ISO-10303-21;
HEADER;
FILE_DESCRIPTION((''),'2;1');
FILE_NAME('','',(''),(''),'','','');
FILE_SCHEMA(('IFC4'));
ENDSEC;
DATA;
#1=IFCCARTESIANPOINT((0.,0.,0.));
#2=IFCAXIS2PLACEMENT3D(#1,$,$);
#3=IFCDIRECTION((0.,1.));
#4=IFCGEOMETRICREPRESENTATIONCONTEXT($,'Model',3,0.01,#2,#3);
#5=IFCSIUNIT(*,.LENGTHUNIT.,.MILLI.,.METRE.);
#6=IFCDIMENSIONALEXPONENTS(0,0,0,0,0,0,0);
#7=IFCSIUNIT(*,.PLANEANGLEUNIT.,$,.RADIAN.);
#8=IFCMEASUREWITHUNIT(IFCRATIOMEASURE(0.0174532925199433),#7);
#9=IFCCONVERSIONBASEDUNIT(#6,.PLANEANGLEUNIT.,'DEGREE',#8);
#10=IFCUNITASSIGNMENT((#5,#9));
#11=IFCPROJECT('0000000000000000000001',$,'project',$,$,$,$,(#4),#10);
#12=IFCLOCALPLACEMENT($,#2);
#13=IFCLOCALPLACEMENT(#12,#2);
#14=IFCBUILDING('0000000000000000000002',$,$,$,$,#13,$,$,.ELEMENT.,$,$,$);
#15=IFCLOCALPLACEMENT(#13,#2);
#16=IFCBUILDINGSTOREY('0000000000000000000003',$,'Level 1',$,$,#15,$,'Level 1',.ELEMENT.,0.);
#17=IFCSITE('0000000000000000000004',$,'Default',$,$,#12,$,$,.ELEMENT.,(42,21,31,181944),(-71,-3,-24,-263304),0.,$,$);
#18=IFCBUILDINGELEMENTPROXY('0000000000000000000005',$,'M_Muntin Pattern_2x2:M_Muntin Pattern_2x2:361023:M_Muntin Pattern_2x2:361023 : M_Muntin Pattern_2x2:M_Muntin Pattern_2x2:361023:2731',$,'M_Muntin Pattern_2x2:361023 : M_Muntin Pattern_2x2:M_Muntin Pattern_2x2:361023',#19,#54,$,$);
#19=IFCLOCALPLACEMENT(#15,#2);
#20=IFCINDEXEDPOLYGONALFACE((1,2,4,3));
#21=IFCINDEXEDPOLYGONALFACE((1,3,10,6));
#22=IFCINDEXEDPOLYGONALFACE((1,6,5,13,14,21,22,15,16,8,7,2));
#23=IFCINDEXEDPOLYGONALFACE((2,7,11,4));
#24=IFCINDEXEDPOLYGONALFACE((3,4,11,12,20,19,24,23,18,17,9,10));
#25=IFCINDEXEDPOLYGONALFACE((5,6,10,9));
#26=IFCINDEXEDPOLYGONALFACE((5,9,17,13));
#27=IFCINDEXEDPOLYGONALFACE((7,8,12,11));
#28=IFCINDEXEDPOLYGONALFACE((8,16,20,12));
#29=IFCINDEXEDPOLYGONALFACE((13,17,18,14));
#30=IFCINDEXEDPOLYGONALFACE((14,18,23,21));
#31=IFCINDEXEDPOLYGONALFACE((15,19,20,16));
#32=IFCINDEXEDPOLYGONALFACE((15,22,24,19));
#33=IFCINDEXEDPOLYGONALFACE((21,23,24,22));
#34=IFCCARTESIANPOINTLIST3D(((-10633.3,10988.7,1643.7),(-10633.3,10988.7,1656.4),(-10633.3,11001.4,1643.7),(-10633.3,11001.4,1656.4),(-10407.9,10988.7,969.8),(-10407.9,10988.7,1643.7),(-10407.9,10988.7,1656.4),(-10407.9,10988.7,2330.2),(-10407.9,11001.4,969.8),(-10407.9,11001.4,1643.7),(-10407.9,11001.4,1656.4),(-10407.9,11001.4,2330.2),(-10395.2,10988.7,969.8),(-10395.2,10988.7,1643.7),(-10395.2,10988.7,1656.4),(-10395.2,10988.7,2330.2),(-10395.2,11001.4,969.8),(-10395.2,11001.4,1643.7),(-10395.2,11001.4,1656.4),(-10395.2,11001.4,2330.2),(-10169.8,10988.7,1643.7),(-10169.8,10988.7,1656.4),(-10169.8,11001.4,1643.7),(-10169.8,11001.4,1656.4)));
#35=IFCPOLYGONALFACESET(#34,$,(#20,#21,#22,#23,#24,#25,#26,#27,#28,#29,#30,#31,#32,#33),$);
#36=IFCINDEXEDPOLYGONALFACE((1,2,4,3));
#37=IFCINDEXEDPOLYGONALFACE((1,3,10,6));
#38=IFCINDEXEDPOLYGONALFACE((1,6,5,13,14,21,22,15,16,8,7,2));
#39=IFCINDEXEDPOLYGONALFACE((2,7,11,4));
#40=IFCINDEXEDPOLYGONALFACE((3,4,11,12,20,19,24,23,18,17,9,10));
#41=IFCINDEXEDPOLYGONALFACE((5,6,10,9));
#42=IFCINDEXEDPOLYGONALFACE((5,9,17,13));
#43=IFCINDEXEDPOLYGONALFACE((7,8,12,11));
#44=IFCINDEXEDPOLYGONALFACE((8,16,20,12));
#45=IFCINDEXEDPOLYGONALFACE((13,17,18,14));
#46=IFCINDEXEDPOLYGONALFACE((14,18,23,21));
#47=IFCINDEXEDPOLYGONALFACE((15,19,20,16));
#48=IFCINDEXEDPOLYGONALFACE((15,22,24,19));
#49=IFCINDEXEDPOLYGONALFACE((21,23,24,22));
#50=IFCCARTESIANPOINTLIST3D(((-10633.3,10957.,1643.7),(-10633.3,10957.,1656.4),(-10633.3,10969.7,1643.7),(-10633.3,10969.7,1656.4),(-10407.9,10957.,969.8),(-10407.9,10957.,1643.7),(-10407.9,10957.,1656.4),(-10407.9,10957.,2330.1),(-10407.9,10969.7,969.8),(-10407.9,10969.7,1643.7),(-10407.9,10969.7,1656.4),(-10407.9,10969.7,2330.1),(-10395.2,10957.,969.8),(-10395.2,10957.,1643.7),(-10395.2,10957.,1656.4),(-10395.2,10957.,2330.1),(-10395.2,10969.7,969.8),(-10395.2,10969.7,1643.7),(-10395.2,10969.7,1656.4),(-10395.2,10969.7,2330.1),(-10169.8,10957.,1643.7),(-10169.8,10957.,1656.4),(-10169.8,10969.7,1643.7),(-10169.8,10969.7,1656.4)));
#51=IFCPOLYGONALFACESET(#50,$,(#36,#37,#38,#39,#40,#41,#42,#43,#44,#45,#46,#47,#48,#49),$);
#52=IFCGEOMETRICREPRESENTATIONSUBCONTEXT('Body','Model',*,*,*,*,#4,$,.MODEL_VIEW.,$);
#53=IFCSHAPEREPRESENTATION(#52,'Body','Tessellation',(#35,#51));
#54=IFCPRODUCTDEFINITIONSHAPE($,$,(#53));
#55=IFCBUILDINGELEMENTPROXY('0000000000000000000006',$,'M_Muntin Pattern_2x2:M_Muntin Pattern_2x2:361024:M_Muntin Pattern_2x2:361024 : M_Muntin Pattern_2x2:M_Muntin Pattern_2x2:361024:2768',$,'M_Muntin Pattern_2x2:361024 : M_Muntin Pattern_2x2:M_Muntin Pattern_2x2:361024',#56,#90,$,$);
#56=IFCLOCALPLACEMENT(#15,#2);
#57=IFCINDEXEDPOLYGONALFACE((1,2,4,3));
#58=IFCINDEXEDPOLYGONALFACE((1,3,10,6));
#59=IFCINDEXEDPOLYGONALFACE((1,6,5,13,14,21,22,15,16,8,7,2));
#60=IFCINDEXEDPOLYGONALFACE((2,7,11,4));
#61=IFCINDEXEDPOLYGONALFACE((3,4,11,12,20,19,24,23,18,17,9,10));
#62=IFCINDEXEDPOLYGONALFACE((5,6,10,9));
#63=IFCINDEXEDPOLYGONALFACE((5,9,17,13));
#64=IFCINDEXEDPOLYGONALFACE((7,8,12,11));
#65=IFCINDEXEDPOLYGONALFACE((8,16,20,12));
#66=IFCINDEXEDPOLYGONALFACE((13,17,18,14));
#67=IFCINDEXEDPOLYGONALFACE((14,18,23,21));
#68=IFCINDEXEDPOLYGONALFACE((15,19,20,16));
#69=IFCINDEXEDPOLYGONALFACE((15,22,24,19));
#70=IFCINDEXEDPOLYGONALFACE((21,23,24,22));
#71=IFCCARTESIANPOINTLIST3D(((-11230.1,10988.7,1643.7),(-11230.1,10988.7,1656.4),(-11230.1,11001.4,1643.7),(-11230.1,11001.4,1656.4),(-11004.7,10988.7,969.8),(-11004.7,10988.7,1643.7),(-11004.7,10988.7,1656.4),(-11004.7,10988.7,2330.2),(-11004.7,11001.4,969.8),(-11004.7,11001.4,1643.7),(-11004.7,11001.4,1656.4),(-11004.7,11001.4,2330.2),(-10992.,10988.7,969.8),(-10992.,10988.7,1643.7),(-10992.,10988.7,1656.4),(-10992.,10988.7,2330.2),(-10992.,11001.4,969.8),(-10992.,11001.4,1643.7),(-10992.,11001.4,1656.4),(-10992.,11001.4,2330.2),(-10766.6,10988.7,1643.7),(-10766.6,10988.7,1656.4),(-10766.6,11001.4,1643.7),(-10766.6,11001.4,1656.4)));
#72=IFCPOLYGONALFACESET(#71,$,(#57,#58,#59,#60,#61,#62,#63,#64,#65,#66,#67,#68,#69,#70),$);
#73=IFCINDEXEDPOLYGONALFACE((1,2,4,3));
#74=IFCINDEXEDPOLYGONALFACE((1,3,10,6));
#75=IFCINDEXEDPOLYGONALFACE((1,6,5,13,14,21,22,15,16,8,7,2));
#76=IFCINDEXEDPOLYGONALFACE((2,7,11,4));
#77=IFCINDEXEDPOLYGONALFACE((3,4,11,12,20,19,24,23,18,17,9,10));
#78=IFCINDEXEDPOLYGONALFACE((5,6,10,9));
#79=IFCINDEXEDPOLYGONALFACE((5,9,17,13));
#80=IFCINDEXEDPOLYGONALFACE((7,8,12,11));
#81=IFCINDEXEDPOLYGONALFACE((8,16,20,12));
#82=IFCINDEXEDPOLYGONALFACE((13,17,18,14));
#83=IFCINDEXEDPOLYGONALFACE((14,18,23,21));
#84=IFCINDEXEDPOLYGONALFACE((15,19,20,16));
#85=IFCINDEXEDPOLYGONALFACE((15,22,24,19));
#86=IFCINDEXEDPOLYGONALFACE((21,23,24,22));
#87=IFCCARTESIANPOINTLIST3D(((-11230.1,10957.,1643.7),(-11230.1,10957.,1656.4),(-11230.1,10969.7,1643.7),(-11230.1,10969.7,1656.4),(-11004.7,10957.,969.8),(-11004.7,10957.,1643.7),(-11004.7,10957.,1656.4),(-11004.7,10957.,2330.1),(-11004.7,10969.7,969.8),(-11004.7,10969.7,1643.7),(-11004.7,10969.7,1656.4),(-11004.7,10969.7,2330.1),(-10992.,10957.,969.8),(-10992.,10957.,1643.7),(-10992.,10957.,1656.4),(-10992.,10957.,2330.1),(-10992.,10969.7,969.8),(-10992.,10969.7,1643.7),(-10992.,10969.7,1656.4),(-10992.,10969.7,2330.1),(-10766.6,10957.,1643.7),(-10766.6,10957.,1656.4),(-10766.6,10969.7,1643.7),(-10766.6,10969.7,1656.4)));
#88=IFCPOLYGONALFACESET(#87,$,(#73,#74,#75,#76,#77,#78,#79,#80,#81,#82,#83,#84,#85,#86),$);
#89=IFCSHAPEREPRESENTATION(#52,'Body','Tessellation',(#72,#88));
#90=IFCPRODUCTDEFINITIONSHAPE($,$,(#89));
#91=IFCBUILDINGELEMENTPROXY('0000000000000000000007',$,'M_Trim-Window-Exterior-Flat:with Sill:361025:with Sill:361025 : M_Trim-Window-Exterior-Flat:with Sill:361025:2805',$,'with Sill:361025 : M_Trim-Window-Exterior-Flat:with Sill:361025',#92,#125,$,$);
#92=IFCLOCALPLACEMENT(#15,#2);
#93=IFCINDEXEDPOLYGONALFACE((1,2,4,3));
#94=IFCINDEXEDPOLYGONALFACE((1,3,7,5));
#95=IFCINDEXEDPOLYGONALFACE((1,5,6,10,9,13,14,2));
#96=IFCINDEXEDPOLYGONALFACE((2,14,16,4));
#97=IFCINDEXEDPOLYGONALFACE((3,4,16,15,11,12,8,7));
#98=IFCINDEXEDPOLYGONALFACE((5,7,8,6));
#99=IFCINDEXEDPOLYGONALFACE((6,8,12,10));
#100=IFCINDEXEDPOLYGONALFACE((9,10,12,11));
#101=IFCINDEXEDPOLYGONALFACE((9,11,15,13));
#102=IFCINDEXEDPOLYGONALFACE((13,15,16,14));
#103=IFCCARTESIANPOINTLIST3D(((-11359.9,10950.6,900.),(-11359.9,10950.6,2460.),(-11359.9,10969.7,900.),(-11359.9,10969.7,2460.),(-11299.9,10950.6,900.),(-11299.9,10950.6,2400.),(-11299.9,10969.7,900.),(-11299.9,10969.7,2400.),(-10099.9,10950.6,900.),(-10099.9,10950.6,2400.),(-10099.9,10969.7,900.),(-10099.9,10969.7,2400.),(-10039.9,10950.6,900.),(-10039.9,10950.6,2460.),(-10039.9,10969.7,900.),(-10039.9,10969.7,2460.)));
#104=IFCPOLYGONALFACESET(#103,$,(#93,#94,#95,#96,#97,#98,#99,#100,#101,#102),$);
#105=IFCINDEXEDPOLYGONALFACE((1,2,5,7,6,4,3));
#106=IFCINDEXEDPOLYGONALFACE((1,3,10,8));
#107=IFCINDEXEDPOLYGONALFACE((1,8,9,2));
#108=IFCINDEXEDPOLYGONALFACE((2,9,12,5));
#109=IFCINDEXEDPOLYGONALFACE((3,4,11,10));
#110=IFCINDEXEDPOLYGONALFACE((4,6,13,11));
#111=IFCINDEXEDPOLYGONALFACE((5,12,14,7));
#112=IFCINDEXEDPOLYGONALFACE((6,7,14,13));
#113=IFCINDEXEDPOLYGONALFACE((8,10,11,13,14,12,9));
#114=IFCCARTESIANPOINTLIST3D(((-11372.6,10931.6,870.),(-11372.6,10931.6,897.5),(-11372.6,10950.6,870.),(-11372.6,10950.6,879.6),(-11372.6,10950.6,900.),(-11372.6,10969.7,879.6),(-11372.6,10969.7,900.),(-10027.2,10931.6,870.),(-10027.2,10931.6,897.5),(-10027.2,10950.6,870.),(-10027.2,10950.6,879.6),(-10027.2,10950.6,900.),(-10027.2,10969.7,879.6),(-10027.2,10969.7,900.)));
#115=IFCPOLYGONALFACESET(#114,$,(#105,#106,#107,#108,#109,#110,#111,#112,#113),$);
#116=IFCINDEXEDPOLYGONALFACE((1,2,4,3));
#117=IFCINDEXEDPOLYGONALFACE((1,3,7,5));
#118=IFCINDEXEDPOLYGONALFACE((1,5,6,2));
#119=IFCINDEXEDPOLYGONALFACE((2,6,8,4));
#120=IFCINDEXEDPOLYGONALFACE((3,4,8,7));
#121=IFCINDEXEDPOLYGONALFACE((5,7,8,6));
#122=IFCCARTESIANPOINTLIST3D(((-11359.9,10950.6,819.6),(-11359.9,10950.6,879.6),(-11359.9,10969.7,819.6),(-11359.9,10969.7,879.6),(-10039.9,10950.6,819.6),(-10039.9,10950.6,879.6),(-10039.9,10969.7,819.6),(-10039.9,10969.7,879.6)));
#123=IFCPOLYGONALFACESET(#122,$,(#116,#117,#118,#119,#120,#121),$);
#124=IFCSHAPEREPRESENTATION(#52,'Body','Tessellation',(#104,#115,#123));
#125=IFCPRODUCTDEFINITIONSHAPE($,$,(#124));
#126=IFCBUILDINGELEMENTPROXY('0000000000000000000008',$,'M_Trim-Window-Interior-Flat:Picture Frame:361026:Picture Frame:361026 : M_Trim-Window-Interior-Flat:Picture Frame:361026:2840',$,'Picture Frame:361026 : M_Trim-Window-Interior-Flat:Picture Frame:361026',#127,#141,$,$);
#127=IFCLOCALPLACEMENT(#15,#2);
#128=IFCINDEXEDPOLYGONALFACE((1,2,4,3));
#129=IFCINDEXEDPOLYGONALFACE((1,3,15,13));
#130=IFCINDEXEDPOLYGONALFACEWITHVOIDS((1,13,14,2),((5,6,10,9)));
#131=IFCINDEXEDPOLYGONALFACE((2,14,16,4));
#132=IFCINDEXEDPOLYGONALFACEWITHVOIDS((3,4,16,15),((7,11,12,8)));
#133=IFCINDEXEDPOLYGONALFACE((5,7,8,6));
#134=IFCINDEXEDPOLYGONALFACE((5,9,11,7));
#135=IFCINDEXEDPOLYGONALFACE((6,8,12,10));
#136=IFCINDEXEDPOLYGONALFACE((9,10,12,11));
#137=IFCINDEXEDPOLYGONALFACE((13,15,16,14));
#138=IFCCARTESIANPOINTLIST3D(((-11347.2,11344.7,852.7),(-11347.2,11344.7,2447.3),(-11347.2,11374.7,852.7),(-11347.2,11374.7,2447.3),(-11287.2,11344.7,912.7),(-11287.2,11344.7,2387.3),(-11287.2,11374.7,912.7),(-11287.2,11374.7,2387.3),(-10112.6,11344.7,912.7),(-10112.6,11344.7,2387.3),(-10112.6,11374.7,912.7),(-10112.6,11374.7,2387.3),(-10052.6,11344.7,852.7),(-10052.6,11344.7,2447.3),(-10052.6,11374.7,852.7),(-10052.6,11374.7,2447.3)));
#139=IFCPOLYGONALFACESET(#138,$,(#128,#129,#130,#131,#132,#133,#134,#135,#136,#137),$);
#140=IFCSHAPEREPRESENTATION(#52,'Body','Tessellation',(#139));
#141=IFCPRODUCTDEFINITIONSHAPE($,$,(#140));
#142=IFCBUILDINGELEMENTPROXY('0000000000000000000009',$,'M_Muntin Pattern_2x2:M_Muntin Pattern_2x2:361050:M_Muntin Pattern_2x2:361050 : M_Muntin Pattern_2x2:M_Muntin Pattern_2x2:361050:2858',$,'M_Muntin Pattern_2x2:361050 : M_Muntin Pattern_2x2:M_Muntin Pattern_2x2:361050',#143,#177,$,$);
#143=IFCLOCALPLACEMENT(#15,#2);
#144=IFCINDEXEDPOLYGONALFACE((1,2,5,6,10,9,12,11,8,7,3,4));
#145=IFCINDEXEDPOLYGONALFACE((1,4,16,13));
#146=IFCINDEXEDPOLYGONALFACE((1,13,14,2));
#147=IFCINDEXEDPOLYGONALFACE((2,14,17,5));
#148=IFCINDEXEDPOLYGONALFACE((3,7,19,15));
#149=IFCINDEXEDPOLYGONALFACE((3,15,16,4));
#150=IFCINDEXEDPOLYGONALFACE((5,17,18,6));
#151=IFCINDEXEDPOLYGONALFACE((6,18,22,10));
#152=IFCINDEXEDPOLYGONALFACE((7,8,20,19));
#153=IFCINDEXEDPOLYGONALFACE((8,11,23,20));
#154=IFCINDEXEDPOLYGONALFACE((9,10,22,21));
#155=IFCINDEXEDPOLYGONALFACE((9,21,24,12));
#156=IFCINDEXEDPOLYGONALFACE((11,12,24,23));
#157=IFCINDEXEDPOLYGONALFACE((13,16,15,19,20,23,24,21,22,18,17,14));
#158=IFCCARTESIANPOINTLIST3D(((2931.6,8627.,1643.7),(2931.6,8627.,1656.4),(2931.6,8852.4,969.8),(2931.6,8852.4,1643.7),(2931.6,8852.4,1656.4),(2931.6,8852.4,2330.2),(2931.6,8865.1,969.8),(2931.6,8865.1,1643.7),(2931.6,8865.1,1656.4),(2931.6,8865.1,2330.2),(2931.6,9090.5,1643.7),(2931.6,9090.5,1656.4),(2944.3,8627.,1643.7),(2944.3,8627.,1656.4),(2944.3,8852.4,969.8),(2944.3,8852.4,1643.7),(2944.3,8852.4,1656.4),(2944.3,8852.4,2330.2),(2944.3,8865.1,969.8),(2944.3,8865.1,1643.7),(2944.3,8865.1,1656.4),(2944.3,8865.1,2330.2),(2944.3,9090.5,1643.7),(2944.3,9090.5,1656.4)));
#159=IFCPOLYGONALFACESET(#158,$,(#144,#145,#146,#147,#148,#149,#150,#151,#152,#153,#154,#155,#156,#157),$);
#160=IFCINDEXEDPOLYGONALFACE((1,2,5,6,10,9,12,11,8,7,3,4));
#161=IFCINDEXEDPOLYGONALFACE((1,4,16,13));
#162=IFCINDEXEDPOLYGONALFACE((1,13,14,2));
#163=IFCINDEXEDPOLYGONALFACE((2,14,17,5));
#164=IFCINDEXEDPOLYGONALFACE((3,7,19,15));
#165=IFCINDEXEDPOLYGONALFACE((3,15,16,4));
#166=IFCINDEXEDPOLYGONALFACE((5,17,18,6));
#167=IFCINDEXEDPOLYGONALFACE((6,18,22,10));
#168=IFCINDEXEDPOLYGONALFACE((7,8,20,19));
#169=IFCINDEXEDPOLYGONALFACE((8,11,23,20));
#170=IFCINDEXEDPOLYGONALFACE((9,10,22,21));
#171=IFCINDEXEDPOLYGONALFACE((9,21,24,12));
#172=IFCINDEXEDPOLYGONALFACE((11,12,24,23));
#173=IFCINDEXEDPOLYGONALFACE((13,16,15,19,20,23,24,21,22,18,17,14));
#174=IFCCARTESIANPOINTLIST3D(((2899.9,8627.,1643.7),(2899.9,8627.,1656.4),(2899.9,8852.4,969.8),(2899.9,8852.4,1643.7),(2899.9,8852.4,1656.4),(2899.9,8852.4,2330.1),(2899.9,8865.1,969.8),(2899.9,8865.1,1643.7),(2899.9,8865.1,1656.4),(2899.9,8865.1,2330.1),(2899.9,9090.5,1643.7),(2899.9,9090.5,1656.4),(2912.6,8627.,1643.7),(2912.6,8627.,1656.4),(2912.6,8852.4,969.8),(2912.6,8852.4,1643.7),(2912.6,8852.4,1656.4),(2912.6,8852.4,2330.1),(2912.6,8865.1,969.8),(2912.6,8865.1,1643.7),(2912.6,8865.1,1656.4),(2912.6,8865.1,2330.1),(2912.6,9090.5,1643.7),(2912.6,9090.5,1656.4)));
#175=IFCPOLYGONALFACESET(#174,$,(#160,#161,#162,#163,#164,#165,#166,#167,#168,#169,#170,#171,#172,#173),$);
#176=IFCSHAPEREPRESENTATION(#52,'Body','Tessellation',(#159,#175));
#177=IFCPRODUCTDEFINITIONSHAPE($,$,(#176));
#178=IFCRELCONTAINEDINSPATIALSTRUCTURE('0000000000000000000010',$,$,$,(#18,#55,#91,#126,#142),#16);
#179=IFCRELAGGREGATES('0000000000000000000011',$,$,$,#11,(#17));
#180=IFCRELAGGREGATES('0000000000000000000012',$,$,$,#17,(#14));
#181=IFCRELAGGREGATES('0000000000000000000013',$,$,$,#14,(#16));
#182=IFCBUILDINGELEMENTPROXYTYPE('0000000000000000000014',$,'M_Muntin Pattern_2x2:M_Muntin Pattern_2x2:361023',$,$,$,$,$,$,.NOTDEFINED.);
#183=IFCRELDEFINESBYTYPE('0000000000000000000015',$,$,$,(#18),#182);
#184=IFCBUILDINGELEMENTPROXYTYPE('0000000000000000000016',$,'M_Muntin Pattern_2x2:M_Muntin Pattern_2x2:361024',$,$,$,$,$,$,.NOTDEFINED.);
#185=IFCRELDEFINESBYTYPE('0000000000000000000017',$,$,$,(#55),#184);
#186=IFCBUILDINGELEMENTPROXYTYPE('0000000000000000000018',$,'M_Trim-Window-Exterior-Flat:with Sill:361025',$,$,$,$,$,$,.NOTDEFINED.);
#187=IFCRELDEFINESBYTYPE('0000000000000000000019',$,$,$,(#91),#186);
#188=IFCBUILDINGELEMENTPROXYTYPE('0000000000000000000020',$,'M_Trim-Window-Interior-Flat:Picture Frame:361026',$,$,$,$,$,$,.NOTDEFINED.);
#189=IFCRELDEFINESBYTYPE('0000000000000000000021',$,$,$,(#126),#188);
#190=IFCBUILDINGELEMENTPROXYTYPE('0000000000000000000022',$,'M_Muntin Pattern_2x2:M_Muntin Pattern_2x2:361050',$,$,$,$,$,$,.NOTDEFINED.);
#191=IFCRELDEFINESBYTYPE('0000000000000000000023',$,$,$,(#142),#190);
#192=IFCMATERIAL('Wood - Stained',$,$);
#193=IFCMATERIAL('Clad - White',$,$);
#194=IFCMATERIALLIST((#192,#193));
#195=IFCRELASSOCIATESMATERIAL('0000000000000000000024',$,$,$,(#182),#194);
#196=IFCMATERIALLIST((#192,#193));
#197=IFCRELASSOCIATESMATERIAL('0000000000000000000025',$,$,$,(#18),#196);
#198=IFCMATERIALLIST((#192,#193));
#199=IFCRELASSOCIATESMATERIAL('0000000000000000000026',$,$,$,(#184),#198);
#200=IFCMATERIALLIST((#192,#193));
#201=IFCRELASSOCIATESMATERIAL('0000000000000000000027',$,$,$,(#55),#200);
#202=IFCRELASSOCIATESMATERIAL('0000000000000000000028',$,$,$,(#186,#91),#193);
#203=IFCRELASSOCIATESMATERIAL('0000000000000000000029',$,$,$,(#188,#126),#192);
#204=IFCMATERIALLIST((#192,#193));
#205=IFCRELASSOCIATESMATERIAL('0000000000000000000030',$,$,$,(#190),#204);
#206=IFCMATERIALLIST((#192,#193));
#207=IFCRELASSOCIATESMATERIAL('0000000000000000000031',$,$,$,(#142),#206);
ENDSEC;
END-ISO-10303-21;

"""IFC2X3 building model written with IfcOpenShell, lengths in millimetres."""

from ifc_helpers import new_model, entity, si_unit, converted_unit, direction, frame, frame_2d, origin, place, context, subcontext, project, spatial, polyline, rectangle, outline, extrude, source, transform, mapped, material, material_list, type_object, type_shapes, element, save


model = new_model("IFC2X3")

# Units and contexts
model_context = context("Model", 3, precision=0.01, world=origin(), true_north=direction((0.0, 1.0)))
body_context = subcontext(model_context, "Body", "Model", "MODEL_VIEW")
ifc_project = project(units=[si_unit("LENGTHUNIT", "METRE", prefix="MILLI"), converted_unit("PLANEANGLEUNIT", "DEGREE", entity("IfcRatioMeasure", 0.0174532925199433), si_unit("PLANEANGLEUNIT", "RADIAN"), dimensions=[0, 0, 0, 0, 0, 0, 0])], contexts=[model_context])

# Site, building, storey
site_placement = place(None, origin())
site = spatial("IfcSite", under=ifc_project, at=site_placement, Name="Default", CompositionType="ELEMENT", RefLatitude=(42, 21, 31, 181944), RefLongitude=(-71, -3, -24, -263304), RefElevation=0.0)
building_placement = place(site_placement, origin())
building = spatial("IfcBuilding", under=site, at=building_placement, CompositionType="ELEMENT")
storey_placement = place(building_placement, origin())
storey = spatial("IfcBuildingStorey", under=building, at=storey_placement, Name="Level 1", LongName="Level 1", CompositionType="ELEMENT", Elevation=0.0)

# Building element proxies
ifc_material_1 = material(Name="Wood - Stained")
ifc_material_2 = material(Name="Clad - White")
ifc_material_list_1 = material_list([ifc_material_1, ifc_material_2])
ifc_material_list_2 = material_list([ifc_material_1, ifc_material_2])
building_element_proxy_type_1 = type_object("IfcBuildingElementProxyType", Name="M_Muntin Pattern_2x2:M_Muntin Pattern_2x2:361023", PredefinedType="NOTDEFINED", material=ifc_material_list_2)
shared_shape_1 = source(origin(), body_context, "Body", "SweptSolid", [
    extrude(outline(polyline([(-680.2, 6.4), (-680.2, -6.3), (-6.4, -6.3), (-6.4, -231.7), (6.3, -231.7), (6.3, -6.3), (680.2, -6.3), (680.2, 6.4), (6.3, 6.4), (6.3, 231.7), (-6.4, 231.7), (-6.4, 6.4), (-680.2, 6.4)])), frame((-10401.5, 10988.7, 1650.0), z_axis=(0.0, -1.0, 0.0), x_axis=(0.0, 0.0, -1.0)), (0.0, 0.0, -1.0), 12.7),
    extrude(outline(polyline([(-680.1, 6.4), (-680.1, -6.3), (-6.4, -6.3), (-6.4, -231.7), (6.3, -231.7), (6.3, -6.3), (680.2, -6.3), (680.2, 6.4), (6.3, 6.4), (6.3, 231.7), (-6.4, 231.7), (-6.4, 6.4), (-680.1, 6.4)])), frame((-10401.5, 10957.0, 1650.0), z_axis=(0.0, -1.0, 0.0), x_axis=(0.0, 0.0, -1.0)), (0.0, 0.0, -1.0), 12.7),
])
type_shapes(building_element_proxy_type_1, [shared_shape_1])
proxy_1_placement = place(storey_placement, origin())
element("IfcBuildingElementProxy", 1, at=proxy_1_placement, inside=storey, type_object=building_element_proxy_type_1, material=ifc_material_list_1, Name="M_Muntin Pattern_2x2:M_Muntin Pattern_2x2:361023:M_Muntin Pattern_2x2:361023 : M_Muntin Pattern_2x2:M_Muntin Pattern_2x2:361023:2731", ObjectType="M_Muntin Pattern_2x2:361023 : M_Muntin Pattern_2x2:M_Muntin Pattern_2x2:361023", context=body_context, shape_type="MappedRepresentation", body=[
    mapped(shared_shape_1, transform((0.0, 0.0, 0.0), scale=1.0)),
])
ifc_material_list_3 = material_list([ifc_material_1, ifc_material_2])
ifc_material_list_4 = material_list([ifc_material_1, ifc_material_2])
building_element_proxy_type_2 = type_object("IfcBuildingElementProxyType", Name="M_Muntin Pattern_2x2:M_Muntin Pattern_2x2:361024", PredefinedType="NOTDEFINED", material=ifc_material_list_4)
shared_shape_2 = source(origin(), body_context, "Body", "SweptSolid", [
    extrude(outline(polyline([(-6.4, -680.1), (6.3, -680.1), (6.3, -6.4), (231.7, -6.4), (231.7, 6.3), (6.3, 6.3), (6.3, 680.2), (-6.4, 680.2), (-6.4, 6.3), (-231.7, 6.3), (-231.7, -6.4), (-6.4, -6.4), (-6.4, -680.1)])), frame((-10998.4, 10988.7, 1650.0), z_axis=(0.0, 1.0, 0.0), x_axis=(1.0, 0.0, 0.0)), (0.0, 0.0, 1.0), 12.7),
    extrude(outline(polyline([(-6.4, -680.1), (6.3, -680.1), (6.3, -6.4), (231.7, -6.4), (231.7, 6.3), (6.3, 6.3), (6.3, 680.2), (-6.4, 680.2), (-6.4, 6.3), (-231.7, 6.3), (-231.7, -6.4), (-6.4, -6.4), (-6.4, -680.1)])), frame((-10998.4, 10957.0, 1650.0), z_axis=(0.0, 1.0, 0.0), x_axis=(1.0, 0.0, 0.0)), (0.0, 0.0, 1.0), 12.7),
])
type_shapes(building_element_proxy_type_2, [shared_shape_2])
proxy_2_placement = place(storey_placement, origin())
element("IfcBuildingElementProxy", 2, at=proxy_2_placement, inside=storey, type_object=building_element_proxy_type_2, material=ifc_material_list_3, Name="M_Muntin Pattern_2x2:M_Muntin Pattern_2x2:361024:M_Muntin Pattern_2x2:361024 : M_Muntin Pattern_2x2:M_Muntin Pattern_2x2:361024:2768", ObjectType="M_Muntin Pattern_2x2:361024 : M_Muntin Pattern_2x2:M_Muntin Pattern_2x2:361024", context=body_context, shape_type="MappedRepresentation", body=[
    mapped(shared_shape_2, transform((0.0, 0.0, 0.0), scale=1.0)),
])
building_element_proxy_type_3 = type_object("IfcBuildingElementProxyType", Name="M_Trim-Window-Exterior-Flat:with Sill:361025", PredefinedType="NOTDEFINED", material=ifc_material_2)
shared_shape_3 = source(origin(), body_context, "Body", "SweptSolid", [
    extrude(outline(polyline([(-765.0, -660.0), (795.0, -660.0), (795.0, 660.0), (-765.0, 660.0), (-765.0, 600.0), (735.0, 600.0), (735.0, -600.0), (-765.0, -600.0), (-765.0, -660.0)])), frame((-10699.9, 10950.6, 1665.0), z_axis=(0.0, 1.0, 0.0), x_axis=(0.0, 0.0, 1.0)), (0.0, 0.0, 1.0), 19.1),
    extrude(outline(polyline([(-15.2, 0.0), (-15.2, -19.0), (12.3, -19.0), (14.8, 0.0), (14.8, 19.0), (-5.7, 19.0), (-5.7, 0.0), (-15.2, 0.0)])), frame((-11372.6, 10950.6, 885.2), z_axis=(-1.0, 0.0, 0.0), x_axis=(0.0, 0.0, 1.0)), (0.0, 0.0, -1.0), 1345.4),
    extrude(rectangle(XDim=19.1, YDim=1320.0, at=frame_2d((0.0, 0.0), x_axis=(1.0, 0.0))), frame((-10699.9, 10960.1, 819.6), z_axis=(0.0, 0.0, 1.0), x_axis=(0.0, 1.0, 0.0)), (0.0, 0.0, 1.0), 60.0),
])
type_shapes(building_element_proxy_type_3, [shared_shape_3])
proxy_3_placement = place(storey_placement, origin())
element("IfcBuildingElementProxy", 3, at=proxy_3_placement, inside=storey, type_object=building_element_proxy_type_3, material=ifc_material_2, Name="M_Trim-Window-Exterior-Flat:with Sill:361025:with Sill:361025 : M_Trim-Window-Exterior-Flat:with Sill:361025:2805", ObjectType="with Sill:361025 : M_Trim-Window-Exterior-Flat:with Sill:361025", context=body_context, shape_type="MappedRepresentation", body=[
    mapped(shared_shape_3, transform((0.0, 0.0, 0.0), scale=1.0)),
])
building_element_proxy_type_4 = type_object("IfcBuildingElementProxyType", Name="M_Trim-Window-Interior-Flat:Picture Frame:361026", PredefinedType="NOTDEFINED", material=ifc_material_1)
shared_shape_4 = source(origin(), body_context, "Body", "SweptSolid", [
    extrude(outline(polyline([(-797.3, -647.3), (797.3, -647.3), (797.3, 647.3), (-797.3, 647.3), (-797.3, -647.3)]), holes=[polyline([(737.3, 587.3), (737.3, -587.3), (-737.3, -587.3), (-737.3, 587.3), (737.3, 587.3)])]), frame((-10699.9, 11344.7, 1650.0), z_axis=(0.0, 1.0, 0.0), x_axis=(0.0, 0.0, -1.0)), (0.0, 0.0, 1.0), 30.0),
])
type_shapes(building_element_proxy_type_4, [shared_shape_4])
proxy_4_placement = place(storey_placement, origin())
element("IfcBuildingElementProxy", 4, at=proxy_4_placement, inside=storey, type_object=building_element_proxy_type_4, material=ifc_material_1, Name="M_Trim-Window-Interior-Flat:Picture Frame:361026:Picture Frame:361026 : M_Trim-Window-Interior-Flat:Picture Frame:361026:2840", ObjectType="Picture Frame:361026 : M_Trim-Window-Interior-Flat:Picture Frame:361026", context=body_context, shape_type="MappedRepresentation", body=[
    mapped(shared_shape_4, transform((0.0, 0.0, 0.0), scale=1.0)),
])
ifc_material_list_5 = material_list([ifc_material_1, ifc_material_2])
ifc_material_list_6 = material_list([ifc_material_1, ifc_material_2])
building_element_proxy_type_5 = type_object("IfcBuildingElementProxyType", Name="M_Muntin Pattern_2x2:M_Muntin Pattern_2x2:361050", PredefinedType="NOTDEFINED", material=ifc_material_list_6)
shared_shape_5 = source(origin(), body_context, "Body", "SweptSolid", [
    extrude(outline(polyline([(-680.2, 6.4), (-680.2, -6.3), (-6.4, -6.3), (-6.4, -231.7), (6.3, -231.7), (6.3, -6.3), (680.2, -6.3), (680.2, 6.4), (6.3, 6.4), (6.3, 231.7), (-6.4, 231.7), (-6.4, 6.4), (-680.2, 6.4)])), frame((2931.6, 8858.7, 1650.0), z_axis=(-1.0, 0.0, 0.0), x_axis=(0.0, 0.0, -1.0)), (0.0, 0.0, -1.0), 12.7),
    extrude(outline(polyline([(-680.1, 6.4), (-680.1, -6.3), (-6.4, -6.3), (-6.4, -231.7), (6.3, -231.7), (6.3, -6.3), (680.2, -6.3), (680.2, 6.4), (6.3, 6.4), (6.3, 231.7), (-6.4, 231.7), (-6.4, 6.4), (-680.1, 6.4)])), frame((2899.9, 8858.7, 1650.0), z_axis=(-1.0, 0.0, 0.0), x_axis=(0.0, 0.0, -1.0)), (0.0, 0.0, -1.0), 12.7),
])
type_shapes(building_element_proxy_type_5, [shared_shape_5])
proxy_5_placement = place(storey_placement, origin())
element("IfcBuildingElementProxy", 5, at=proxy_5_placement, inside=storey, type_object=building_element_proxy_type_5, material=ifc_material_list_5, Name="M_Muntin Pattern_2x2:M_Muntin Pattern_2x2:361050:M_Muntin Pattern_2x2:361050 : M_Muntin Pattern_2x2:M_Muntin Pattern_2x2:361050:2858", ObjectType="M_Muntin Pattern_2x2:361050 : M_Muntin Pattern_2x2:M_Muntin Pattern_2x2:361050", context=body_context, shape_type="MappedRepresentation", body=[
    mapped(shared_shape_5, transform((0.0, 0.0, 0.0), scale=1.0)),
])

save(model, "model.ifc")
